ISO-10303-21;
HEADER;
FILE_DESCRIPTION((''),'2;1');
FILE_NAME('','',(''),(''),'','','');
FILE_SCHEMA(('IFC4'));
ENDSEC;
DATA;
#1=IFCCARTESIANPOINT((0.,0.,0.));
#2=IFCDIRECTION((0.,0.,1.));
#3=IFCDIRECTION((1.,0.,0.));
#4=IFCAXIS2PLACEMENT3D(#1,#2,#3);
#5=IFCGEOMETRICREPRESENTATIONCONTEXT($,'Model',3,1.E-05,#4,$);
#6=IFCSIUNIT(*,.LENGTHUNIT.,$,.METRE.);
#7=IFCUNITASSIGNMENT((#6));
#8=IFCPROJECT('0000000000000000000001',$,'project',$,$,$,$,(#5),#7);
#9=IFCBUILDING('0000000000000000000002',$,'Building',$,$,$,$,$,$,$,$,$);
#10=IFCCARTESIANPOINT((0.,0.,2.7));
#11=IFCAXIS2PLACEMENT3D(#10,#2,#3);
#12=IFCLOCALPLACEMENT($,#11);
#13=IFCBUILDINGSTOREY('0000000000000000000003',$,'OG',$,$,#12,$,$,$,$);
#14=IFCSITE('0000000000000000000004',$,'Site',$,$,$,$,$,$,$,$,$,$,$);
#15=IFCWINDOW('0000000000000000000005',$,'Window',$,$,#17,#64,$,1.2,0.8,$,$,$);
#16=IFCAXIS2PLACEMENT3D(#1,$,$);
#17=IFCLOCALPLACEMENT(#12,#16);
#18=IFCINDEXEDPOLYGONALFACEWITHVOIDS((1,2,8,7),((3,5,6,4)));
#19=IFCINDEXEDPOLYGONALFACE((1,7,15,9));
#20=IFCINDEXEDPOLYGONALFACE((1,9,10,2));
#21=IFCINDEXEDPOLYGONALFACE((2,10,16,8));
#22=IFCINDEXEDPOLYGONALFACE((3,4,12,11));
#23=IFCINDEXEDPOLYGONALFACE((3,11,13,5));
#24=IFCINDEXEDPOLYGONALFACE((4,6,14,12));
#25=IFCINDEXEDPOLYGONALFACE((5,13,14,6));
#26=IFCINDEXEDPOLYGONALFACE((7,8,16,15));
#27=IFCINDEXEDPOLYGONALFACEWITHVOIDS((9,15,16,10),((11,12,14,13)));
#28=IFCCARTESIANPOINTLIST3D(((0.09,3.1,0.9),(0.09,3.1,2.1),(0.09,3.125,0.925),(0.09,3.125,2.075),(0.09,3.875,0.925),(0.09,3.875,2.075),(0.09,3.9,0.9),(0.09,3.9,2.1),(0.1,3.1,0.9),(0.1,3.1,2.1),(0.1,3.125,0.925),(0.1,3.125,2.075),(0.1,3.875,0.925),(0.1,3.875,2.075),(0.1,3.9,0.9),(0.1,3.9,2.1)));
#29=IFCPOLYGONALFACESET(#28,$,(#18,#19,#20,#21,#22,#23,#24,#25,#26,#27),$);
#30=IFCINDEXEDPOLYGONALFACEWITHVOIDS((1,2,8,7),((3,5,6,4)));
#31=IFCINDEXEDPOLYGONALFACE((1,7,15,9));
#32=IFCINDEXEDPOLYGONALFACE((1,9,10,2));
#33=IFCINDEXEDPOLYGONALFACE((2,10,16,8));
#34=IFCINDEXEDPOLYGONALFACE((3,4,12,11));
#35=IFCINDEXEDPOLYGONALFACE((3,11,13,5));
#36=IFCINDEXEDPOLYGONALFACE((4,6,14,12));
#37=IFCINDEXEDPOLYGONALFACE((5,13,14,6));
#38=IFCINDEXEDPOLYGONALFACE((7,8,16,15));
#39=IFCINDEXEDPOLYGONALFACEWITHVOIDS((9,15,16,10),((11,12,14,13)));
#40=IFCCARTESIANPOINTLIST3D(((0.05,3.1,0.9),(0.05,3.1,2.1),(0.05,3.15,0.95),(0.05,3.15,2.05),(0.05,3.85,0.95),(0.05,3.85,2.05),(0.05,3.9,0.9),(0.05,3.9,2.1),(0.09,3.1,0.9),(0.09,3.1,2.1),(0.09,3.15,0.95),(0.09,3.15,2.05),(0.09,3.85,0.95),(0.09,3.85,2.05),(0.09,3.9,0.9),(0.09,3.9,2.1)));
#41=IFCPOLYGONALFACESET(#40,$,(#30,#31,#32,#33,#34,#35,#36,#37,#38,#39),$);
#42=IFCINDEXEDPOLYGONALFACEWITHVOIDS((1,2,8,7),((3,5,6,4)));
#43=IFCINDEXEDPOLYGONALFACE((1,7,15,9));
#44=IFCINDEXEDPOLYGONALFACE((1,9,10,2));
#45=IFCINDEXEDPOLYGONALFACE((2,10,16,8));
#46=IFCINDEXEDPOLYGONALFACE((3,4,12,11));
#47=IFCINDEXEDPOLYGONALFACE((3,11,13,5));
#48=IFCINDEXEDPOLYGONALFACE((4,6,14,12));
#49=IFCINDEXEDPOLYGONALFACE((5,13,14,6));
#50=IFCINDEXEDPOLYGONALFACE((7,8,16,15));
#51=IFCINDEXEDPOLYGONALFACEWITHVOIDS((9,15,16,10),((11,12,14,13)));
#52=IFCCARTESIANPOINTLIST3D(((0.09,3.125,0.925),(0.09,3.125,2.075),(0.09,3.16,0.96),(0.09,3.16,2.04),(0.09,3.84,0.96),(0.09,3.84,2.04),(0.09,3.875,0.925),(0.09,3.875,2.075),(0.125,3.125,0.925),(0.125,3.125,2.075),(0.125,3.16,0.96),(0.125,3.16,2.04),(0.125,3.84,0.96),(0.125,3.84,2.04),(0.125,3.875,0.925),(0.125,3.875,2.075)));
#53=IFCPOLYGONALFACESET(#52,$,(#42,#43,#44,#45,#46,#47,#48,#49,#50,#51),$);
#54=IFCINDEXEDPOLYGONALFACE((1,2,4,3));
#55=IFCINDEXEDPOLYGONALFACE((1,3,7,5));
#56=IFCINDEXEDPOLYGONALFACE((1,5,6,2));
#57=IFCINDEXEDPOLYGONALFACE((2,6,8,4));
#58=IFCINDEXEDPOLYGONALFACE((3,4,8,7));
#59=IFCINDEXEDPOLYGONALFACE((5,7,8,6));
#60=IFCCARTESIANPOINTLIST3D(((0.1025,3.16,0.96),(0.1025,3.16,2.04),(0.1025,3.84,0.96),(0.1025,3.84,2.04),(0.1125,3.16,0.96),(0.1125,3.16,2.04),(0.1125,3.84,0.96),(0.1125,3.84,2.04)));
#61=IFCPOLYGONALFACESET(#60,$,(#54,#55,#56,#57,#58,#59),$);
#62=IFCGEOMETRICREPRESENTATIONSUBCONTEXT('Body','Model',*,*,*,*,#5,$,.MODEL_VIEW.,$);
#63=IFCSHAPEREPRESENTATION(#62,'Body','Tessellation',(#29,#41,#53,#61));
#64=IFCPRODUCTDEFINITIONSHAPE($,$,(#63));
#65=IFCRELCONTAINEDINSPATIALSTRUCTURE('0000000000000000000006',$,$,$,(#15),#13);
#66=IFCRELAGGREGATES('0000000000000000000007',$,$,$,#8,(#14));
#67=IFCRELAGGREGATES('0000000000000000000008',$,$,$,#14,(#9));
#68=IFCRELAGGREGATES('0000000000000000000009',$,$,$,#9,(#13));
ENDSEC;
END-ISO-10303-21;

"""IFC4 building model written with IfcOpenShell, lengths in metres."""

from ifc_helpers import new_model, si_unit, frame, origin_with_axes, place, context, subcontext, project, spatial, line, indexed_curve, outline, extrude, element, save


model = new_model("IFC4")

# Units and contexts
model_context = context("Model", 3, precision=1e-05, world=origin_with_axes())
body_context = subcontext(model_context, "Body", "Model", "MODEL_VIEW")
ifc_project = project(units=[si_unit("LENGTHUNIT", "METRE")], contexts=[model_context])

# Site, building, storey
site = spatial("IfcSite", under=ifc_project, Name="Site")
building = spatial("IfcBuilding", under=site, Name="Building")
storey_placement = place(None, frame((0.0, 0.0, 2.7), z_axis=(0.0, 0.0, 1.0), x_axis=(1.0, 0.0, 0.0)))
storey = spatial("IfcBuildingStorey", under=building, at=storey_placement, Name="OG")

# Window
window_1_placement = place(storey_placement, frame((0.0, 3.9, 0.9), z_axis=(0.0, 0.0, 1.0), x_axis=(0.0, -1.0, 0.0)))
element("IfcWindow", 1, at=window_1_placement, inside=storey, Name="Window", OverallHeight=1.2, OverallWidth=0.8, context=body_context, shape_type="SweptSolid", body=[
    extrude(outline(indexed_curve([(0.0, 0.0), (0.8, 0.0), (0.8, 1.2), (0.0, 1.2)], segments=[line(1, 2, 3, 4, 1)]), holes=[indexed_curve([(0.025, 0.025), (0.775, 0.025), (0.775, 1.175), (0.025, 1.175)], segments=[line(1, 2, 3, 4, 1)])]), frame((0.0, 0.09, 0.0), z_axis=(0.0, -1.0, 0.0), x_axis=(1.0, 0.0, 0.0)), (0.0, 0.0, -1.0), 0.01),
    extrude(outline(indexed_curve([(0.0, 0.0), (0.8, 0.0), (0.8, 1.2), (0.0, 1.2)], segments=[line(1, 2, 3, 4, 1)]), holes=[indexed_curve([(0.05, 0.05), (0.75, 0.05), (0.75, 1.15), (0.05, 1.15)], segments=[line(1, 2, 3, 4, 1)])]), frame((0.0, 0.05, 0.0), z_axis=(0.0, -1.0, 0.0), x_axis=(1.0, 0.0, 0.0)), (0.0, 0.0, -1.0), 0.04),
    extrude(outline(indexed_curve([(0.0, 0.0), (0.75, 0.0), (0.75, 1.15), (0.0, 1.15)], segments=[line(1, 2, 3, 4, 1)]), holes=[indexed_curve([(0.035, 0.035), (0.715, 0.035), (0.715, 1.115), (0.035, 1.115)], segments=[line(1, 2, 3, 4, 1)])]), frame((0.025, 0.09, 0.025), z_axis=(0.0, -1.0, 0.0), x_axis=(1.0, 0.0, 0.0)), (0.0, 0.0, -1.0), 0.035),
    extrude(outline(indexed_curve([(0.035, 0.035), (0.715, 0.035), (0.715, 1.115), (0.035, 1.115)], segments=[line(1, 2, 3, 4, 1)])), frame((0.025, 0.1025, 0.025), z_axis=(0.0, -1.0, 0.0), x_axis=(1.0, 0.0, 0.0)), (0.0, 0.0, -1.0), 0.01),
])

save(model, "model.ifc")
